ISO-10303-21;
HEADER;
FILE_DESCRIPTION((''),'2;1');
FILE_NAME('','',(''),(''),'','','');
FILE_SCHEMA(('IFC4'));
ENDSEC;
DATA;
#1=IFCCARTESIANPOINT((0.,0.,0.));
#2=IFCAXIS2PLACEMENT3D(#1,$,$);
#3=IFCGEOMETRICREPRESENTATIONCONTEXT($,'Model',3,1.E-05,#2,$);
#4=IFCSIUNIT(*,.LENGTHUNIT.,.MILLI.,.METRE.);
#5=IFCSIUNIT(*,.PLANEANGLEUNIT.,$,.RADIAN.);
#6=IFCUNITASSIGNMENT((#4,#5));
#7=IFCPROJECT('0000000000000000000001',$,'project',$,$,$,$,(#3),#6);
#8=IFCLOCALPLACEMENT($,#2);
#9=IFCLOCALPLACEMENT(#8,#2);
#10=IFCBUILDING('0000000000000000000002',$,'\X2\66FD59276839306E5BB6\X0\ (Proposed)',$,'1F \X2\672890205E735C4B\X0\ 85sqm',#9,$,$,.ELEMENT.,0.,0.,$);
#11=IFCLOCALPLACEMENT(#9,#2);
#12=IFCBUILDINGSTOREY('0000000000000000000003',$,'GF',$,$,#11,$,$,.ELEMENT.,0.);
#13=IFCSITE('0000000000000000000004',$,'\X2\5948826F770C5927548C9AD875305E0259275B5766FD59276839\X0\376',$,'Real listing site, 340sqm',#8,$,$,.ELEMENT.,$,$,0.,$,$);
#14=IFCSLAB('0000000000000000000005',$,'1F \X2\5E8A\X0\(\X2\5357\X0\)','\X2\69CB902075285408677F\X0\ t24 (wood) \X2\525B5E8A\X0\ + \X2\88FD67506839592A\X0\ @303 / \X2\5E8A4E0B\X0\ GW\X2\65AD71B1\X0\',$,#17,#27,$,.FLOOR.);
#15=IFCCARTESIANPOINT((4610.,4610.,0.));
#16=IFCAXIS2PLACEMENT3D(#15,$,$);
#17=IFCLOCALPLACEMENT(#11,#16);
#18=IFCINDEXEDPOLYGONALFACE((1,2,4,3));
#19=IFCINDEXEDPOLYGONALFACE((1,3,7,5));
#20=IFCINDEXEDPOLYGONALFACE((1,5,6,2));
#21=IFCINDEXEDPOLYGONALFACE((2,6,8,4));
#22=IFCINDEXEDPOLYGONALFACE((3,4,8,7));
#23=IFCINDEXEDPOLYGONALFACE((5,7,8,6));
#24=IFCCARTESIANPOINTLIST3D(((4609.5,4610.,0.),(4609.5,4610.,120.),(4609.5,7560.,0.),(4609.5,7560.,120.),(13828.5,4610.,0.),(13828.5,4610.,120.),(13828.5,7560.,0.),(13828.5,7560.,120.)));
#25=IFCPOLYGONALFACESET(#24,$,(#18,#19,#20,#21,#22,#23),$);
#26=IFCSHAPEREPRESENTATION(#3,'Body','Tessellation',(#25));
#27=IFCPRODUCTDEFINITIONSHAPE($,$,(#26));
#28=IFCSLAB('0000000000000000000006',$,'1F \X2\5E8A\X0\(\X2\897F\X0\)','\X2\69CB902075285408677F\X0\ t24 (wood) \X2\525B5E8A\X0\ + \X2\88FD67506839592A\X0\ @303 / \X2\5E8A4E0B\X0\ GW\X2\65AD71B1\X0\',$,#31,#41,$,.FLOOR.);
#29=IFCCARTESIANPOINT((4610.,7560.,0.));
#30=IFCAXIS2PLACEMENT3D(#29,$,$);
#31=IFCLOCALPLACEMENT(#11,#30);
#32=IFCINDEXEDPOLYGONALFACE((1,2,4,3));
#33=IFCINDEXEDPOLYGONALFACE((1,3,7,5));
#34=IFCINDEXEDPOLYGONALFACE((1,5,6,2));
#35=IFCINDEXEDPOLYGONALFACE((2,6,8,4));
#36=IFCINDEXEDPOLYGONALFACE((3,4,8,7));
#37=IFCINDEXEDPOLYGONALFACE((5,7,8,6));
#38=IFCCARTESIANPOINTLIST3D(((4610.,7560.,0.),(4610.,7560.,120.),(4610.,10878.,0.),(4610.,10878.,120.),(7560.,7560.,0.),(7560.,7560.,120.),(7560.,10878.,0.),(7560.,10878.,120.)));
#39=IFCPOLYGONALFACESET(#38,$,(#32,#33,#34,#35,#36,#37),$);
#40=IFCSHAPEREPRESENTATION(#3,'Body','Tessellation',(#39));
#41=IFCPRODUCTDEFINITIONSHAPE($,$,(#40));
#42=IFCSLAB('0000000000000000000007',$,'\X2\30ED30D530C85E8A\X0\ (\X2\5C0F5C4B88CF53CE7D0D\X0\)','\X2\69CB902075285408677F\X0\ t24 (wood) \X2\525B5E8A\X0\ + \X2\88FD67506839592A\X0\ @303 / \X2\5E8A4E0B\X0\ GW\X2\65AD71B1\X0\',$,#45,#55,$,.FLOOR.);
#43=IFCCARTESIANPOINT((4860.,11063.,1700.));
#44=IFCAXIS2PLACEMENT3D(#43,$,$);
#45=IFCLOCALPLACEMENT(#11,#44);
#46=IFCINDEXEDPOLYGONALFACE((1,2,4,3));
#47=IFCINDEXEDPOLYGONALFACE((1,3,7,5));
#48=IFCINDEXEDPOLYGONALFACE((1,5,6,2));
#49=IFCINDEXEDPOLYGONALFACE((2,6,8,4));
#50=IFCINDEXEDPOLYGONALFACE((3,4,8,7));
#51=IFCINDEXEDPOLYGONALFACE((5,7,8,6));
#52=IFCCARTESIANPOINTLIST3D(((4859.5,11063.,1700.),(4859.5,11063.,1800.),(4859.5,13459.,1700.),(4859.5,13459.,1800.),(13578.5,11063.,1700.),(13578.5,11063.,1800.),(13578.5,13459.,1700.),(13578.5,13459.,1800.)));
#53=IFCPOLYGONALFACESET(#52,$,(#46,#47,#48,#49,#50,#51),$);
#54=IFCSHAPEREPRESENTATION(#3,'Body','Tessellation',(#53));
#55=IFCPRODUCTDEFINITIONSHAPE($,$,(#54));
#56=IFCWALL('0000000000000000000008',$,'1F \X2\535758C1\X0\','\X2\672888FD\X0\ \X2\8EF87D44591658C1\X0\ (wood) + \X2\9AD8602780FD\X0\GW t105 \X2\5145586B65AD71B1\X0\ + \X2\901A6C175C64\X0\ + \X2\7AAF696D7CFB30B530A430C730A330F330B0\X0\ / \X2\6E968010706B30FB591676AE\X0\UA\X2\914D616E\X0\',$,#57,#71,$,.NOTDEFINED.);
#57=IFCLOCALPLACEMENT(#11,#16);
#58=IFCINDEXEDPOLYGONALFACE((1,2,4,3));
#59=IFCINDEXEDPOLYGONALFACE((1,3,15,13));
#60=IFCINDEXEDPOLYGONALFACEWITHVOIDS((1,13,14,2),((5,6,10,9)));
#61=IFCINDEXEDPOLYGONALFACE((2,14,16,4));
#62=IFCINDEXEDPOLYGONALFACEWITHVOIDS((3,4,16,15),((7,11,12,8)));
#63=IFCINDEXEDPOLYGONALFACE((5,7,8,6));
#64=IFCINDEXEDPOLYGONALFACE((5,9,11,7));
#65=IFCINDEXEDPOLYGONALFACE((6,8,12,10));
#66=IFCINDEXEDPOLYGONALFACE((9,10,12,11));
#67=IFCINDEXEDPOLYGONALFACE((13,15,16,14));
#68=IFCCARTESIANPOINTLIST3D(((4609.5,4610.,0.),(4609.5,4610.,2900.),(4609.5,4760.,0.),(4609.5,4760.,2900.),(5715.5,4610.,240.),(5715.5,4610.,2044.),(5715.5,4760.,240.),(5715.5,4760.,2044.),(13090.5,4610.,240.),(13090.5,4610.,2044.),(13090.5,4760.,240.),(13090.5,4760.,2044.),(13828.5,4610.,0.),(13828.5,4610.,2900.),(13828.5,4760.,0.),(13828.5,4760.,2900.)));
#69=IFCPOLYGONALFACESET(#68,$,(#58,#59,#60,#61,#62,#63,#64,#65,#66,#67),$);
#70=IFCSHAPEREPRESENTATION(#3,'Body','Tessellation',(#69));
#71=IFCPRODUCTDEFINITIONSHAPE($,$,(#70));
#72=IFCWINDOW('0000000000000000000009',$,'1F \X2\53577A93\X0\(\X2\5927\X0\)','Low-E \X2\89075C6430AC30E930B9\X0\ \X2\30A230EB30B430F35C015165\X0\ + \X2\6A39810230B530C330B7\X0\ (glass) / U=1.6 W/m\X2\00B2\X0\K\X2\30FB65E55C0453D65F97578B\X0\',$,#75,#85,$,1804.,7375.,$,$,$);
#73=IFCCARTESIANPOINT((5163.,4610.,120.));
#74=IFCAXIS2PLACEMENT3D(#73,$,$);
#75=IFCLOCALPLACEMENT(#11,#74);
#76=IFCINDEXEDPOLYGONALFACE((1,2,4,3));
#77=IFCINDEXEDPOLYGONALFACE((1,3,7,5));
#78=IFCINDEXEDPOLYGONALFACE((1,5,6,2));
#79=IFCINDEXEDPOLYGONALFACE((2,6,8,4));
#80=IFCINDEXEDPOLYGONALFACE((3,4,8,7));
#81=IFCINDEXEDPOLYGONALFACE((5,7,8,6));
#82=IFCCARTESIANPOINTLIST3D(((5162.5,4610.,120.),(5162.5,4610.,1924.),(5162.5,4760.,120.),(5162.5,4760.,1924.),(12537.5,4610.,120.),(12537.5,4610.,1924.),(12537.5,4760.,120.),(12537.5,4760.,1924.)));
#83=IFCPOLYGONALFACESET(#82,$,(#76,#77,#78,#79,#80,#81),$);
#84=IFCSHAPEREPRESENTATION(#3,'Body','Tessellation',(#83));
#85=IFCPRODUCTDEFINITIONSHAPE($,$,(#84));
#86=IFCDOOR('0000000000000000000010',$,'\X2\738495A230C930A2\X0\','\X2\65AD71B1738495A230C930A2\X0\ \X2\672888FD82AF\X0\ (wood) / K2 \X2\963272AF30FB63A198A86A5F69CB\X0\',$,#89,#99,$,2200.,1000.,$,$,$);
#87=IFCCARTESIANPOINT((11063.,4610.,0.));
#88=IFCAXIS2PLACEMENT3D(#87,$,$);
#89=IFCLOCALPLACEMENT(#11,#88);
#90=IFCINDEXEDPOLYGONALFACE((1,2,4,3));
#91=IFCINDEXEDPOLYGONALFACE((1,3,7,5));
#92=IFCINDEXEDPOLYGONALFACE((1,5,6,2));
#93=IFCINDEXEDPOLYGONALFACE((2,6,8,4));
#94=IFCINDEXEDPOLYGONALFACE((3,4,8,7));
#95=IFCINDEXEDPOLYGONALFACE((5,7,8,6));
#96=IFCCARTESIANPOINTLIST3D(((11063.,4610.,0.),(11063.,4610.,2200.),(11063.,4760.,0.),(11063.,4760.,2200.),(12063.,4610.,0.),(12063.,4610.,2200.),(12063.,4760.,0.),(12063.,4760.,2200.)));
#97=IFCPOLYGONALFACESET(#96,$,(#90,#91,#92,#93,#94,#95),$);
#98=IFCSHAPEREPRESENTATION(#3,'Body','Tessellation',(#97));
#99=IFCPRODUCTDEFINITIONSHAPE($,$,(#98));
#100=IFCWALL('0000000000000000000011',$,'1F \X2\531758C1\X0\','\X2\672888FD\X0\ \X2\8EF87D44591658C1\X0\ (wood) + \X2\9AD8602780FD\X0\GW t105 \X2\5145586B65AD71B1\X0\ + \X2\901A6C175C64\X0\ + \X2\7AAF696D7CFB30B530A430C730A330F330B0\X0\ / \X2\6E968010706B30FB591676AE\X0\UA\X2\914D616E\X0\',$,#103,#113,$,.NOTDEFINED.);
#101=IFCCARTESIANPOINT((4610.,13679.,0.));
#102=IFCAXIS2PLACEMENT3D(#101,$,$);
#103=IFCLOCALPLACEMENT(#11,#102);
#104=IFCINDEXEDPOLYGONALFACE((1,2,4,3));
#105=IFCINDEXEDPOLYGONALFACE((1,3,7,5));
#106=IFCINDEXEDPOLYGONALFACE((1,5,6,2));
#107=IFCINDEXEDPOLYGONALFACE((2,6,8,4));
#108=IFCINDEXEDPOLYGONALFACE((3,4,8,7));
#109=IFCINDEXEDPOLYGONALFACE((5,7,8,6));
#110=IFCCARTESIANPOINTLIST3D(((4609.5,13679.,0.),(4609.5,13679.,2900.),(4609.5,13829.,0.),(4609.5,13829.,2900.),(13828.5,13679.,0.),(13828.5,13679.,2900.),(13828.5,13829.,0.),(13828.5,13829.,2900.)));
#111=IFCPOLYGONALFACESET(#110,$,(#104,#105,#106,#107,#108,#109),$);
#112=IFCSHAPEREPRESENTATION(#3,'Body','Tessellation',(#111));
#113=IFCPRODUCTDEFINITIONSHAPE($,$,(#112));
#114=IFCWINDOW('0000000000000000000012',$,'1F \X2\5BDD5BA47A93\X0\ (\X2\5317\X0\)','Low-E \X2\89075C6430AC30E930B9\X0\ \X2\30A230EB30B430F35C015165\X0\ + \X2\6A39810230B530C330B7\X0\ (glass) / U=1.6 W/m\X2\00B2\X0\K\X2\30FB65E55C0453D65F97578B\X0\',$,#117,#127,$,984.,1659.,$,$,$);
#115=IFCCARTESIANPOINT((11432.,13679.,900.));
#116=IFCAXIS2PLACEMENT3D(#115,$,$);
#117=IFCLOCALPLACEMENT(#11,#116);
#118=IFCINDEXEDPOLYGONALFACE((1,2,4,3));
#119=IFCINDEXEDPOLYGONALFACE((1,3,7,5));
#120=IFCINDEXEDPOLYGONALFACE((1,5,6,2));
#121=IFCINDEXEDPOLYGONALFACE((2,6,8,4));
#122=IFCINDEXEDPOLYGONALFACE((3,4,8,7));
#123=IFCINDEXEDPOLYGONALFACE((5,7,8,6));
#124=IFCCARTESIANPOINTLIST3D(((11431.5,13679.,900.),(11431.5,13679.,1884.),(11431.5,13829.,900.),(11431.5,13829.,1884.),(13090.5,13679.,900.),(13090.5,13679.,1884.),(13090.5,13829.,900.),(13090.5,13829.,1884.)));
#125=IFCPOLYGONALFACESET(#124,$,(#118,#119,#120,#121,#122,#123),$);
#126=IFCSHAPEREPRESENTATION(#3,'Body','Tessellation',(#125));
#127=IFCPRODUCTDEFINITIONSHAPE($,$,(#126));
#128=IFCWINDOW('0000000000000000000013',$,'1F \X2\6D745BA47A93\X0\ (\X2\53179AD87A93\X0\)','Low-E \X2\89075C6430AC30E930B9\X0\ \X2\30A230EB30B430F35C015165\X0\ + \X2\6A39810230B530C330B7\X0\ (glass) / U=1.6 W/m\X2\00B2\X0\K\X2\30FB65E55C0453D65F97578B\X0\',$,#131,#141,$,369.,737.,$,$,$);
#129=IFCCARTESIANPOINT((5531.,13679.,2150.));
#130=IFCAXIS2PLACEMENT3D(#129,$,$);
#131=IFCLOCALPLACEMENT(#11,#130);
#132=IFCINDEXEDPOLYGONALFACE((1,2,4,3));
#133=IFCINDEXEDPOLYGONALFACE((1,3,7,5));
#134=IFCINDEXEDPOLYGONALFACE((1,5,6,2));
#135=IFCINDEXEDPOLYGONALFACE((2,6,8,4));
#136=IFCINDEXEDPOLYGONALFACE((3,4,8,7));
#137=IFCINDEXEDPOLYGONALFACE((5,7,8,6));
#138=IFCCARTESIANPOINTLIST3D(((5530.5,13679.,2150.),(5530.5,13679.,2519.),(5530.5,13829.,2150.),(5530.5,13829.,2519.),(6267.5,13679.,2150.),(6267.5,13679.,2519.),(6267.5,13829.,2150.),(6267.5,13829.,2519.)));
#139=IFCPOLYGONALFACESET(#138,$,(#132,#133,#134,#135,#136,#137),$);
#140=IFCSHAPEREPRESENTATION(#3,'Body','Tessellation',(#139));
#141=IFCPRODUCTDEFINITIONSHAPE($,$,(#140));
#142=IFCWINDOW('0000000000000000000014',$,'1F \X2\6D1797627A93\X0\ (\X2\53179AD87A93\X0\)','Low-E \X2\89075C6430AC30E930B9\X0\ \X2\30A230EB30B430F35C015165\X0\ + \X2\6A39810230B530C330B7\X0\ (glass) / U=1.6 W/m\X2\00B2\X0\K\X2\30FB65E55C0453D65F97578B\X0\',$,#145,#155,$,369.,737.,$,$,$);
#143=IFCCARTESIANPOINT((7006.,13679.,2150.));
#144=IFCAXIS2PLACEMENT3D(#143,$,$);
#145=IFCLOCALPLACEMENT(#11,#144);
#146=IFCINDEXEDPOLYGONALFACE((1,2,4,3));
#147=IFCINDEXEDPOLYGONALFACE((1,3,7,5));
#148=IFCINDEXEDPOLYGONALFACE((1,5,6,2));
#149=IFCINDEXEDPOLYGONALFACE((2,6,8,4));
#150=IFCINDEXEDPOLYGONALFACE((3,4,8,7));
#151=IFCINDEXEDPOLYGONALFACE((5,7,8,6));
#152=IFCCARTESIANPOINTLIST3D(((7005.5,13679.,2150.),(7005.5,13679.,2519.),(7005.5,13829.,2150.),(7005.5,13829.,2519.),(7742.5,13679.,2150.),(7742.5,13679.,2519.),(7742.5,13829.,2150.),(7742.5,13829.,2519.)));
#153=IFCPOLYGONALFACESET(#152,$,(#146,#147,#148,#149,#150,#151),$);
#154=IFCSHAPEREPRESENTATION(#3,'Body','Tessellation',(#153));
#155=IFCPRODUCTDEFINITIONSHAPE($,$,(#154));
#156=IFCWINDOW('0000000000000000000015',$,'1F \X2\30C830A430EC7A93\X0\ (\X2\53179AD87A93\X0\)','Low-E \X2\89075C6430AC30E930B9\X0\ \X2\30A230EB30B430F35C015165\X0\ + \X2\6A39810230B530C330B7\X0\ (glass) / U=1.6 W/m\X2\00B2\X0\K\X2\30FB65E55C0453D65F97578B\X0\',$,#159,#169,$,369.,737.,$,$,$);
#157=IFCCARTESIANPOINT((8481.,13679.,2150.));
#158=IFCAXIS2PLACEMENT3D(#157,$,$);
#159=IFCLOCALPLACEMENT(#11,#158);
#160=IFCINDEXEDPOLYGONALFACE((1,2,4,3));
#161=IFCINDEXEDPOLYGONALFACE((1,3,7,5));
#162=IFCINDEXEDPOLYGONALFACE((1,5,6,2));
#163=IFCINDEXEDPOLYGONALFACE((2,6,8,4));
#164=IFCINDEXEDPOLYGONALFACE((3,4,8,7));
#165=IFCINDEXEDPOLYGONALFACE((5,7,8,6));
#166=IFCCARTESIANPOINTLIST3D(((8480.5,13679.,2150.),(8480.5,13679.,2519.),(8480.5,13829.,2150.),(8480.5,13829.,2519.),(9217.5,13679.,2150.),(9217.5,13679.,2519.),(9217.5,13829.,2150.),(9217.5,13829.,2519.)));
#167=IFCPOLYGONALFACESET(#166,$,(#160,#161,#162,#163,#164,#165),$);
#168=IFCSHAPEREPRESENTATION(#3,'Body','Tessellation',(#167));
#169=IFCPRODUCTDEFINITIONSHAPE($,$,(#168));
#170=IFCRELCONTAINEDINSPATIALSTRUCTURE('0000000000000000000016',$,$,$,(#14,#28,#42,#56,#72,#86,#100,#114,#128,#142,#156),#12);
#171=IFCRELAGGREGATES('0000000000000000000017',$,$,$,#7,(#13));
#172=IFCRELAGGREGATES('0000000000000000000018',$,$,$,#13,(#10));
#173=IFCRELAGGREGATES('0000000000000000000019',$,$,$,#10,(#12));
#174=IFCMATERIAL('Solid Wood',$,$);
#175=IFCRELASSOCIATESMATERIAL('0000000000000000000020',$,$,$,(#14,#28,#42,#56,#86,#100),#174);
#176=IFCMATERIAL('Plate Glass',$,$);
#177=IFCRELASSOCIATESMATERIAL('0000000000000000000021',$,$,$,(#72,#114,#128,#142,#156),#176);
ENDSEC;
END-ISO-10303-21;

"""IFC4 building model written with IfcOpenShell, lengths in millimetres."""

from ifc_helpers import new_model, si_unit, frame, frame_2d, origin, place, context, project, spatial, rectangle, extrude, material, element, fill, save


model = new_model("IFC4")

# Units and contexts
model_context = context("Model", 3, precision=1e-05, world=origin())
ifc_project = project(units=[si_unit("LENGTHUNIT", "METRE", prefix="MILLI"), si_unit("PLANEANGLEUNIT", "RADIAN")], contexts=[model_context])

# Site, building, storey
site_placement = place(None, origin())
site = spatial("IfcSite", under=ifc_project, at=site_placement, Name="奈良県大和高田市大字曽大根376", ObjectType="Real listing site, 340sqm", CompositionType="ELEMENT", RefElevation=0.0)
building_placement = place(site_placement, origin())
building = spatial("IfcBuilding", under=site, at=building_placement, Name="曽大根の家 (Proposed)", ObjectType="1F 木造平屋 85sqm", CompositionType="ELEMENT", ElevationOfRefHeight=0.0, ElevationOfTerrain=0.0)
storey_placement = place(building_placement, origin())
storey = spatial("IfcBuildingStorey", under=building, at=storey_placement, Name="GF", CompositionType="ELEMENT", Elevation=0.0)

# Slabs
ifc_material_1 = material(Name="Solid Wood")
slab_1_placement = place(storey_placement, frame((4610.0, 4610.0, 0.0)))
element("IfcSlab", 1, at=slab_1_placement, inside=storey, material=ifc_material_1, Name="1F 床(南)", Description="構造用合板 t24 (wood) 剛床 + 製材根太 @303 / 床下 GW断熱", PredefinedType="FLOOR", context=model_context, shape_type="SweptSolid", body=[
    extrude(rectangle(XDim=9219.0, YDim=2950.0, at=frame_2d((4609.0, 1475.0))), frame((4610.0, 4610.0, 0.0)), (0.0, 0.0, 1.0), 120.0),
])
slab_2_placement = place(storey_placement, frame((4610.0, 7560.0, 0.0)))
element("IfcSlab", 2, at=slab_2_placement, inside=storey, material=ifc_material_1, Name="1F 床(西)", Description="構造用合板 t24 (wood) 剛床 + 製材根太 @303 / 床下 GW断熱", PredefinedType="FLOOR", context=model_context, shape_type="SweptSolid", body=[
    extrude(rectangle(XDim=2950.0, YDim=3318.0, at=frame_2d((1475.0, 1659.0))), frame((4610.0, 7560.0, 0.0)), (0.0, 0.0, 1.0), 120.0),
])
slab_3_placement = place(storey_placement, frame((4860.0, 11063.0, 1700.0)))
element("IfcSlab", 3, at=slab_3_placement, inside=storey, material=ifc_material_1, Name="ロフト床 (小屋裏収納)", Description="構造用合板 t24 (wood) 剛床 + 製材根太 @303 / 床下 GW断熱", PredefinedType="FLOOR", context=model_context, shape_type="SweptSolid", body=[
    extrude(rectangle(XDim=8719.0, YDim=2396.0, at=frame_2d((4359.0, 1198.0))), frame((4860.0, 11063.0, 1700.0)), (0.0, 0.0, 1.0), 100.0),
])

# Wall, openings, window, door
wall_1_placement = place(storey_placement, frame((4610.0, 4610.0, 0.0)))
wall_1 = element("IfcWall", 4, at=wall_1_placement, inside=storey, material=ifc_material_1, Name="1F 南壁", Description="木製 軸組外壁 (wood) + 高性能GW t105 充填断熱 + 通気層 + 窯業系サイディング / 準耐火・外皮UA配慮", PredefinedType="NOTDEFINED", context=model_context, shape_type="SweptSolid", body=[
    extrude(rectangle(XDim=9219.0, YDim=150.0, at=frame_2d((4609.0, 75.0))), frame((4610.0, 4610.0, 0.0)), (0.0, 0.0, 1.0), 2900.0),
])
opening_1_placement = place(storey_placement, frame((5163.0, 4610.0, 120.0)))
opening_1 = element("IfcOpeningElement", 5, at=opening_1_placement, cuts=wall_1, PredefinedType="NOTDEFINED", context=model_context, shape_type="SweptSolid", body=[
    extrude(rectangle(XDim=7375.0, YDim=150.0, at=frame_2d((3687.0, 75.0))), frame((5163.0, 4610.0, 120.0)), (0.0, 0.0, 1.0), 1804.0),
])
opening_2_placement = place(storey_placement, frame((11063.0, 4610.0, 0.0)))
opening_2 = element("IfcOpeningElement", 6, at=opening_2_placement, cuts=wall_1, PredefinedType="NOTDEFINED", context=model_context, shape_type="SweptSolid", body=[
    extrude(rectangle(XDim=1000.0, YDim=150.0, at=frame_2d((500.0, 75.0))), frame((11063.0, 4610.0, 0.0)), (0.0, 0.0, 1.0), 2200.0),
])
ifc_material_2 = material(Name="Plate Glass")
window_1_placement = place(storey_placement, frame((5163.0, 4610.0, 120.0)))
window_1 = element("IfcWindow", 7, at=window_1_placement, inside=storey, material=ifc_material_2, Name="1F 南窓(大)", Description="Low-E 複層ガラス アルゴン封入 + 樹脂サッシ (glass) / U=1.6 W/m²K・日射取得型", OverallHeight=1804.0, OverallWidth=7375.0, context=model_context, shape_type="SweptSolid", body=[
    extrude(rectangle(XDim=7375.0, YDim=150.0, at=frame_2d((3687.0, 75.0))), frame((5163.0, 4610.0, 120.0)), (0.0, 0.0, 1.0), 1804.0),
])
fill(opening_1, window_1)
door_1_placement = place(storey_placement, frame((11063.0, 4610.0, 0.0)))
door_1 = element("IfcDoor", 8, at=door_1_placement, inside=storey, material=ifc_material_1, Name="玄関ドア", Description="断熱玄関ドア 木製芯 (wood) / K2 防犯・採風機構", OverallHeight=2200.0, OverallWidth=1000.0, context=model_context, shape_type="SweptSolid", body=[
    extrude(rectangle(XDim=1000.0, YDim=150.0, at=frame_2d((500.0, 75.0))), frame((11063.0, 4610.0, 0.0)), (0.0, 0.0, 1.0), 2200.0),
])
fill(opening_2, door_1)

# Wall, openings, windows
wall_2_placement = place(storey_placement, frame((4610.0, 13679.0, 0.0)))
wall_2 = element("IfcWall", 9, at=wall_2_placement, inside=storey, material=ifc_material_1, Name="1F 北壁", Description="木製 軸組外壁 (wood) + 高性能GW t105 充填断熱 + 通気層 + 窯業系サイディング / 準耐火・外皮UA配慮", PredefinedType="NOTDEFINED", context=model_context, shape_type="SweptSolid", body=[
    extrude(rectangle(XDim=9219.0, YDim=150.0, at=frame_2d((4609.0, 75.0))), frame((4610.0, 13679.0, 0.0)), (0.0, 0.0, 1.0), 2900.0),
])
opening_3_placement = place(storey_placement, frame((11432.0, 13679.0, 900.0)))
opening_3 = element("IfcOpeningElement", 10, at=opening_3_placement, cuts=wall_2, PredefinedType="NOTDEFINED", context=model_context, shape_type="SweptSolid", body=[
    extrude(rectangle(XDim=1659.0, YDim=150.0, at=frame_2d((829.0, 75.0))), frame((11432.0, 13679.0, 900.0)), (0.0, 0.0, 1.0), 984.0),
])
opening_4_placement = place(storey_placement, frame((5531.0, 13679.0, 2150.0)))
opening_4 = element("IfcOpeningElement", 11, at=opening_4_placement, cuts=wall_2, PredefinedType="NOTDEFINED", context=model_context, shape_type="SweptSolid", body=[
    extrude(rectangle(XDim=737.0, YDim=150.0, at=frame_2d((368.0, 75.0))), frame((5531.0, 13679.0, 2150.0)), (0.0, 0.0, 1.0), 369.0),
])
opening_5_placement = place(storey_placement, frame((7006.0, 13679.0, 2150.0)))
opening_5 = element("IfcOpeningElement", 12, at=opening_5_placement, cuts=wall_2, PredefinedType="NOTDEFINED", context=model_context, shape_type="SweptSolid", body=[
    extrude(rectangle(XDim=737.0, YDim=150.0, at=frame_2d((368.0, 75.0))), frame((7006.0, 13679.0, 2150.0)), (0.0, 0.0, 1.0), 369.0),
])
opening_6_placement = place(storey_placement, frame((8481.0, 13679.0, 2150.0)))
opening_6 = element("IfcOpeningElement", 13, at=opening_6_placement, cuts=wall_2, PredefinedType="NOTDEFINED", context=model_context, shape_type="SweptSolid", body=[
    extrude(rectangle(XDim=737.0, YDim=150.0, at=frame_2d((368.0, 75.0))), frame((8481.0, 13679.0, 2150.0)), (0.0, 0.0, 1.0), 369.0),
])
window_2_placement = place(storey_placement, frame((11432.0, 13679.0, 900.0)))
window_2 = element("IfcWindow", 14, at=window_2_placement, inside=storey, material=ifc_material_2, Name="1F 寝室窓 (北)", Description="Low-E 複層ガラス アルゴン封入 + 樹脂サッシ (glass) / U=1.6 W/m²K・日射取得型", OverallHeight=984.0, OverallWidth=1659.0, context=model_context, shape_type="SweptSolid", body=[
    extrude(rectangle(XDim=1659.0, YDim=150.0, at=frame_2d((829.0, 75.0))), frame((11432.0, 13679.0, 900.0)), (0.0, 0.0, 1.0), 984.0),
])
fill(opening_3, window_2)
window_3_placement = place(storey_placement, frame((5531.0, 13679.0, 2150.0)))
window_3 = element("IfcWindow", 15, at=window_3_placement, inside=storey, material=ifc_material_2, Name="1F 浴室窓 (北高窓)", Description="Low-E 複層ガラス アルゴン封入 + 樹脂サッシ (glass) / U=1.6 W/m²K・日射取得型", OverallHeight=369.0, OverallWidth=737.0, context=model_context, shape_type="SweptSolid", body=[
    extrude(rectangle(XDim=737.0, YDim=150.0, at=frame_2d((368.0, 75.0))), frame((5531.0, 13679.0, 2150.0)), (0.0, 0.0, 1.0), 369.0),
])
fill(opening_4, window_3)
window_4_placement = place(storey_placement, frame((7006.0, 13679.0, 2150.0)))
window_4 = element("IfcWindow", 16, at=window_4_placement, inside=storey, material=ifc_material_2, Name="1F 洗面窓 (北高窓)", Description="Low-E 複層ガラス アルゴン封入 + 樹脂サッシ (glass) / U=1.6 W/m²K・日射取得型", OverallHeight=369.0, OverallWidth=737.0, context=model_context, shape_type="SweptSolid", body=[
    extrude(rectangle(XDim=737.0, YDim=150.0, at=frame_2d((368.0, 75.0))), frame((7006.0, 13679.0, 2150.0)), (0.0, 0.0, 1.0), 369.0),
])
fill(opening_5, window_4)
window_5_placement = place(storey_placement, frame((8481.0, 13679.0, 2150.0)))
window_5 = element("IfcWindow", 17, at=window_5_placement, inside=storey, material=ifc_material_2, Name="1F トイレ窓 (北高窓)", Description="Low-E 複層ガラス アルゴン封入 + 樹脂サッシ (glass) / U=1.6 W/m²K・日射取得型", OverallHeight=369.0, OverallWidth=737.0, context=model_context, shape_type="SweptSolid", body=[
    extrude(rectangle(XDim=737.0, YDim=150.0, at=frame_2d((368.0, 75.0))), frame((8481.0, 13679.0, 2150.0)), (0.0, 0.0, 1.0), 369.0),
])
fill(opening_6, window_5)

save(model, "model.ifc")
